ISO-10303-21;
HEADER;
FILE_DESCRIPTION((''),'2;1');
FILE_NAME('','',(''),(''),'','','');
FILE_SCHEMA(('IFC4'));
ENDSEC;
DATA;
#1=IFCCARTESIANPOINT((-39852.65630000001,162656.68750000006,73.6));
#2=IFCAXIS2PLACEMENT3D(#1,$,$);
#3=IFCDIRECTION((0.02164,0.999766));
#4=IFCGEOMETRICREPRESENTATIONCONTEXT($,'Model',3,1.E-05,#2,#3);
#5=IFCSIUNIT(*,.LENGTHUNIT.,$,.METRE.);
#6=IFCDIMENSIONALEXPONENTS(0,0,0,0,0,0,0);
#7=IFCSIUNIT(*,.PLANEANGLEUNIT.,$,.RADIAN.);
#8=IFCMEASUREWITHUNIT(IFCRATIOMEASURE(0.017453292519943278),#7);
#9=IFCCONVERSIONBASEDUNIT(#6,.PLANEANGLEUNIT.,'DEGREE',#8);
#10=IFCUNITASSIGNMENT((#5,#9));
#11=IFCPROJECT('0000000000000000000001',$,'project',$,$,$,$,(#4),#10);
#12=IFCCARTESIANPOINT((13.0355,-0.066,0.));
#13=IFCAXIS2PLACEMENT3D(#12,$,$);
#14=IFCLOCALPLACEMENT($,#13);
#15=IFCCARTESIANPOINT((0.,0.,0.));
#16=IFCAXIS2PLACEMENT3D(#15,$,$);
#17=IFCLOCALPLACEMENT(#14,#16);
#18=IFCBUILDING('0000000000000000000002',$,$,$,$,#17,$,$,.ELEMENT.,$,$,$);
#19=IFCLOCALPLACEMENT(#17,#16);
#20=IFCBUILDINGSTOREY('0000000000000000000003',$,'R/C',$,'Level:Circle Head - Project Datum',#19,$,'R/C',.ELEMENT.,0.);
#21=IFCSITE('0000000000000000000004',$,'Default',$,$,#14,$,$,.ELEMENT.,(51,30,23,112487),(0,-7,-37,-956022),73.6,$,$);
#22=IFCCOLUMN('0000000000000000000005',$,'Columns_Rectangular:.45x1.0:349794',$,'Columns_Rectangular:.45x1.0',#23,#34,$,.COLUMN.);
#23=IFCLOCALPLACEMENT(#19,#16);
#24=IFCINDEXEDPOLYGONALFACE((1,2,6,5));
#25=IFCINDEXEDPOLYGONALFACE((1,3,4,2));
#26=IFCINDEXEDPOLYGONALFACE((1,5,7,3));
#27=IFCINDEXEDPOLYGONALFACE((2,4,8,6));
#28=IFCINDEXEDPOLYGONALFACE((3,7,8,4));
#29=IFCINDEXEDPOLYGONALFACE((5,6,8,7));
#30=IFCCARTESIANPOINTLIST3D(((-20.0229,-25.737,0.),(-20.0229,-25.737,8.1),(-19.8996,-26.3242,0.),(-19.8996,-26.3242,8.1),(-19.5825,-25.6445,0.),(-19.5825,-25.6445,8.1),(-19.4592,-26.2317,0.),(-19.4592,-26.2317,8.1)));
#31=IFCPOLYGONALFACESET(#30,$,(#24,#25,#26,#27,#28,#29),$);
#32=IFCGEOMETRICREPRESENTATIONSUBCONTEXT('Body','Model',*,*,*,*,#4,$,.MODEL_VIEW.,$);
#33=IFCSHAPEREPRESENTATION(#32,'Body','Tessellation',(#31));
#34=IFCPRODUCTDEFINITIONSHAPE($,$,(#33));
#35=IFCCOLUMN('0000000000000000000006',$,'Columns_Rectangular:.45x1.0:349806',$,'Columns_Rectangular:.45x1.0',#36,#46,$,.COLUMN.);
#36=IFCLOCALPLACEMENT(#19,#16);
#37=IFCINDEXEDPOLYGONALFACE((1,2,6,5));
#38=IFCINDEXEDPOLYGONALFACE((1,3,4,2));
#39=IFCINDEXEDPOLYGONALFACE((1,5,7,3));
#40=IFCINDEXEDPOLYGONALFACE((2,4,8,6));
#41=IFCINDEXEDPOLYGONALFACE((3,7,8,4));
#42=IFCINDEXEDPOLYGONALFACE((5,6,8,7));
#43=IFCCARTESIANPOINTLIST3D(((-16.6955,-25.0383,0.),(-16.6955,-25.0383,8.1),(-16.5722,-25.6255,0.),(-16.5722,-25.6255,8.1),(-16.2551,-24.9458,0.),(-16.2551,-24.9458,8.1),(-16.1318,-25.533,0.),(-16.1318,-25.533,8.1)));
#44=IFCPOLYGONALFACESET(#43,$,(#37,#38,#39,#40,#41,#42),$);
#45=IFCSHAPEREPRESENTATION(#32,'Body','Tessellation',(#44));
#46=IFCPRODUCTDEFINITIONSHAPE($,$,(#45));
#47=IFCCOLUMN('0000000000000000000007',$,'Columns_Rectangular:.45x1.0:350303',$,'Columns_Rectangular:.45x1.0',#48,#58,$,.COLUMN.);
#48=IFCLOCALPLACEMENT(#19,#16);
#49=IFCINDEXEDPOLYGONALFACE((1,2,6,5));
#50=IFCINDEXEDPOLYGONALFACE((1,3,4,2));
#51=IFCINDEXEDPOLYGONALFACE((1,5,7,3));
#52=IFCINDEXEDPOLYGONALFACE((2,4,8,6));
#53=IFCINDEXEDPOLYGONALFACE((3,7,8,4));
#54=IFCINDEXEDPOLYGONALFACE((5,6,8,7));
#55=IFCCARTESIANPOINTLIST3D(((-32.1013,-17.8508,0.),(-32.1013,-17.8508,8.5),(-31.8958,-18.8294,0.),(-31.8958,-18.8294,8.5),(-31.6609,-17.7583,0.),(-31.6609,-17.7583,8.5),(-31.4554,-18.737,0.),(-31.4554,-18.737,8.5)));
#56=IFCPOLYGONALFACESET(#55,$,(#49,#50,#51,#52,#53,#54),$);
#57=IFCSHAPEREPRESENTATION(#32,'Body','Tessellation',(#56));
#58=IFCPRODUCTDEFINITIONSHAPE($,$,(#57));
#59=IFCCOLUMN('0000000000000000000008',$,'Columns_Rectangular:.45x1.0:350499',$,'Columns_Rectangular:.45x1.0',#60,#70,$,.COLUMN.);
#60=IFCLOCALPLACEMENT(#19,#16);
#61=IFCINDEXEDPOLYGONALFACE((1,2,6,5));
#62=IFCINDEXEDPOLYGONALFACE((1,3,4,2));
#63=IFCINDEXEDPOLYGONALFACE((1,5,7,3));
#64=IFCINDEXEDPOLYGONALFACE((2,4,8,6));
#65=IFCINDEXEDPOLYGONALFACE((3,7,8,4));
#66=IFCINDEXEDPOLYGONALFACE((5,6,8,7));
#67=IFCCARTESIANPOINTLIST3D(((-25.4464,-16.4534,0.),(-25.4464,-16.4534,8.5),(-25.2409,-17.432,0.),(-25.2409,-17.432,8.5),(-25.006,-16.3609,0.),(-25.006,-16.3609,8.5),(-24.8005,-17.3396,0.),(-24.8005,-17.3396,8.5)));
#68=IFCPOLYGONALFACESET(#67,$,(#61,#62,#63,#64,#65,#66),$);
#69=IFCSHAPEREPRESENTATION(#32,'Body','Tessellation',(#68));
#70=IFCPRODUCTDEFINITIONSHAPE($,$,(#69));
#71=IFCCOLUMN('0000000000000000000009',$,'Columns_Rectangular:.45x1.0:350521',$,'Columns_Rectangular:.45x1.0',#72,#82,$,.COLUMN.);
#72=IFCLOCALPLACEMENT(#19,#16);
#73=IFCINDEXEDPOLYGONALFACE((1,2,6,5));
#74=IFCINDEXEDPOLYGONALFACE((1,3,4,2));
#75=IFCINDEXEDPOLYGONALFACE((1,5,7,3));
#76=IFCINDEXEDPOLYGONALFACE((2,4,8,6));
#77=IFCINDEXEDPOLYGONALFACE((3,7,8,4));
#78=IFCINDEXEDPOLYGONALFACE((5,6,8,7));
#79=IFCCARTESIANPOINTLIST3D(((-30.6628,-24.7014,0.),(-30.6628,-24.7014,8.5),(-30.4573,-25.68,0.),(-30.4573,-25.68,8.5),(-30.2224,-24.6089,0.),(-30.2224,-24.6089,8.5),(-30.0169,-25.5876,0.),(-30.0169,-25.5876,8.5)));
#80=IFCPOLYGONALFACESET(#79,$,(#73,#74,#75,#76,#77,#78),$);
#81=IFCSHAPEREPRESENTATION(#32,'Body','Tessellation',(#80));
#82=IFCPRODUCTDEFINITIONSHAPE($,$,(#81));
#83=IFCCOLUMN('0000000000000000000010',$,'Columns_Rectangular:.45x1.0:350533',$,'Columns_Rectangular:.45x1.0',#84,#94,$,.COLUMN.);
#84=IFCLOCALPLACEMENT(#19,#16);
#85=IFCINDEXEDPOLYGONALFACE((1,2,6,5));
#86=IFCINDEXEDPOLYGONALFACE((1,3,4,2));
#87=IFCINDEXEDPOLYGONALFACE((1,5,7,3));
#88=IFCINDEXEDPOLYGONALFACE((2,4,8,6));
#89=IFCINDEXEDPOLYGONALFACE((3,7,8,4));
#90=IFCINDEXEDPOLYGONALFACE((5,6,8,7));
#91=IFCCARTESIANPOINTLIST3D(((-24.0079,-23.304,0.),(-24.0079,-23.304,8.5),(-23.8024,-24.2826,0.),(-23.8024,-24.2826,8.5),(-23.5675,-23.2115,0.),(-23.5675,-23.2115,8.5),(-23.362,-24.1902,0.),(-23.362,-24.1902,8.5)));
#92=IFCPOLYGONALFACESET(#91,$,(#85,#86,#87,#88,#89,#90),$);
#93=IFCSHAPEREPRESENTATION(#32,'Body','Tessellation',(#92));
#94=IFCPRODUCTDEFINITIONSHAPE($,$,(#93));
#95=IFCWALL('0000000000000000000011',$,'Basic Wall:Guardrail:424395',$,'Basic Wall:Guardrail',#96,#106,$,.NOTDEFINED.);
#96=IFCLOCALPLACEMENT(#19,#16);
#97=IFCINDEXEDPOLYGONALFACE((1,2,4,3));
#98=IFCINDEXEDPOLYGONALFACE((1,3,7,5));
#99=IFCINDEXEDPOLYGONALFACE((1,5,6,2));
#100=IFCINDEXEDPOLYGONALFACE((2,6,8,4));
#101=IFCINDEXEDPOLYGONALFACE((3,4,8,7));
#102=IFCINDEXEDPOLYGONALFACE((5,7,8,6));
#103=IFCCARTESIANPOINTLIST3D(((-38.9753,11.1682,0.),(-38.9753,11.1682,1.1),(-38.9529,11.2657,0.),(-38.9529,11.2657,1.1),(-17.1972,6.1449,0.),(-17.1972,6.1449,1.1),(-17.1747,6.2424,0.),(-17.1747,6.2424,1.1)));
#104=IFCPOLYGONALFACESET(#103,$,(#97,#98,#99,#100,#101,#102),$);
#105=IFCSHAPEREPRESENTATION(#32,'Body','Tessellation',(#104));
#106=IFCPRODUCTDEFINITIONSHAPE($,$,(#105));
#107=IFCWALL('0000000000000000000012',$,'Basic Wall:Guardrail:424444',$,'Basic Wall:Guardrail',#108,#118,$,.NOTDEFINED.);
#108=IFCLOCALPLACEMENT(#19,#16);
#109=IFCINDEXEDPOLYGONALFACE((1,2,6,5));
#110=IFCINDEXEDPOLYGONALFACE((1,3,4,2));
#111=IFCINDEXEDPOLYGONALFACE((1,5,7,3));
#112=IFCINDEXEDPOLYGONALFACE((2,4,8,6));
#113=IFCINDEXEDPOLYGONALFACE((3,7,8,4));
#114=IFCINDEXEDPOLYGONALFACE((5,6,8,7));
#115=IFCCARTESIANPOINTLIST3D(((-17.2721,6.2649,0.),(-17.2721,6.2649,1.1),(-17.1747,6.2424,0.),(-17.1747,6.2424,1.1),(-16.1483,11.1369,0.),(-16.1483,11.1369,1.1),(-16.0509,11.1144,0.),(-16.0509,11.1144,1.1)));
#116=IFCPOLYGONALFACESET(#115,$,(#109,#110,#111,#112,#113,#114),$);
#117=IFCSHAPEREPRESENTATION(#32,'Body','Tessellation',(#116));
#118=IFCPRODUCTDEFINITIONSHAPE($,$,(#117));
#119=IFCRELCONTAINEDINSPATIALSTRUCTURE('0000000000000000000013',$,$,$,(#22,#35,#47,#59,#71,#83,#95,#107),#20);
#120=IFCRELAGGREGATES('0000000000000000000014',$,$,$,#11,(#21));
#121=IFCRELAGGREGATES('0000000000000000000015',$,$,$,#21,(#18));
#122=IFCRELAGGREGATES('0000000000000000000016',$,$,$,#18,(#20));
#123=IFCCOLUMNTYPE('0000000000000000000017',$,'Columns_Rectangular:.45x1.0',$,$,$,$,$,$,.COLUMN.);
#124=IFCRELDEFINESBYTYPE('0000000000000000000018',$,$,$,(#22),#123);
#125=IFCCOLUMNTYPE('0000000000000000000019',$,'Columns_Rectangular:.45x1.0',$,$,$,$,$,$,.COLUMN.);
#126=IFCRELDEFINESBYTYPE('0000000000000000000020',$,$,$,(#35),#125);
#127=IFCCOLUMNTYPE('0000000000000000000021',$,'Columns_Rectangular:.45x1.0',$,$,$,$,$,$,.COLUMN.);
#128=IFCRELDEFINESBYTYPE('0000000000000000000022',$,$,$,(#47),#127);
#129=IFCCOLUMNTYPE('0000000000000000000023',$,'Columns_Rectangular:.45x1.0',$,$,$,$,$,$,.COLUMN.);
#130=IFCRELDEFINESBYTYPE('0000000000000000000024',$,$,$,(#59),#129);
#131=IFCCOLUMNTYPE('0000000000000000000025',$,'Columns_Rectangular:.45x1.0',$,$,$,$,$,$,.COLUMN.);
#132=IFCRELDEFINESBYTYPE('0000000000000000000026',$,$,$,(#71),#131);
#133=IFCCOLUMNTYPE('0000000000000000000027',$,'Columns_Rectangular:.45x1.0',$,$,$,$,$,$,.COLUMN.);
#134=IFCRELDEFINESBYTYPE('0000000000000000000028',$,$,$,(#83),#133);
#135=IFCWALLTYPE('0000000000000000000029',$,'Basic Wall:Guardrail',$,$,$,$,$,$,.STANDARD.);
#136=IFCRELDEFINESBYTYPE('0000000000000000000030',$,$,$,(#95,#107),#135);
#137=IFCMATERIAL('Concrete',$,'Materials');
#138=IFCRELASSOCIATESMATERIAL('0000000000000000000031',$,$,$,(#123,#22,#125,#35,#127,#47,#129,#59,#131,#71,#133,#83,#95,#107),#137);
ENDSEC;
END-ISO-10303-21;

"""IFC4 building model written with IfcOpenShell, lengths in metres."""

from ifc_helpers import new_model, entity, si_unit, converted_unit, direction, frame, origin, place, context, subcontext, project, spatial, indexed_curve, outline, extrude, source, transform, mapped, material, type_object, type_shapes, element, save


model = new_model("IFC4")

# Units and contexts
model_context = context("Model", 3, precision=1e-05, world=frame((-39852.65630000001, 162656.68750000006, 73.6)), true_north=direction((0.02164, 0.999766)))
body_context = subcontext(model_context, "Body", "Model", "MODEL_VIEW")
ifc_project = project(units=[si_unit("LENGTHUNIT", "METRE"), converted_unit("PLANEANGLEUNIT", "DEGREE", entity("IfcRatioMeasure", 0.017453292519943278), si_unit("PLANEANGLEUNIT", "RADIAN"), dimensions=[0, 0, 0, 0, 0, 0, 0])], contexts=[model_context])

# Site, building, storey
site_placement = place(None, frame((13.0355, -0.066, 0.0)))
site = spatial("IfcSite", under=ifc_project, at=site_placement, Name="Default", CompositionType="ELEMENT", RefLatitude=(51, 30, 23, 112487), RefLongitude=(0, -7, -37, -956022), RefElevation=73.6)
building_placement = place(site_placement, origin())
building = spatial("IfcBuilding", under=site, at=building_placement, CompositionType="ELEMENT")
storey_placement = place(building_placement, origin())
storey = spatial("IfcBuildingStorey", under=building, at=storey_placement, Name="R/C", ObjectType="Level:Circle Head - Project Datum", LongName="R/C", CompositionType="ELEMENT", Elevation=0.0)

# Columns
ifc_material = material(Name="Concrete", Category="Materials")
column_type_1 = type_object("IfcColumnType", Name="Columns_Rectangular:.45x1.0", PredefinedType="COLUMN", material=ifc_material)
shared_shape_1 = source(origin(), body_context, "Body", "SweptSolid", [
    extrude(outline(indexed_curve([(-0.3, -0.225), (0.3, -0.225), (0.3, 0.225), (-0.3, 0.225), (-0.3, -0.225)], self_intersect=False)), frame((-19.741, -25.9844, 0.0), z_axis=(0.0, 0.0, 1.0), x_axis=(-0.2055, 0.978657, 0.0)), (0.0, 0.0, 1.0), 8.1),
])
type_shapes(column_type_1, [shared_shape_1])
column_1_placement = place(storey_placement, origin())
element("IfcColumn", 1, at=column_1_placement, inside=storey, type_object=column_type_1, material=ifc_material, Name="Columns_Rectangular:.45x1.0:349794", ObjectType="Columns_Rectangular:.45x1.0", PredefinedType="COLUMN", context=body_context, shape_type="MappedRepresentation", body=[
    mapped(shared_shape_1, transform((0.0, 0.0, 0.0), scale=1.0)),
])
column_type_2 = type_object("IfcColumnType", Name="Columns_Rectangular:.45x1.0", PredefinedType="COLUMN", material=ifc_material)
shared_shape_2 = source(origin(), body_context, "Body", "SweptSolid", [
    extrude(outline(indexed_curve([(-0.3, -0.225), (0.3, -0.225), (0.3, 0.225), (-0.3, 0.225), (-0.3, -0.225)], self_intersect=False)), frame((-16.4136, -25.2857, 0.0), z_axis=(0.0, 0.0, 1.0), x_axis=(-0.2055, 0.978657, 0.0)), (0.0, 0.0, 1.0), 8.1),
])
type_shapes(column_type_2, [shared_shape_2])
column_2_placement = place(storey_placement, origin())
element("IfcColumn", 2, at=column_2_placement, inside=storey, type_object=column_type_2, material=ifc_material, Name="Columns_Rectangular:.45x1.0:349806", ObjectType="Columns_Rectangular:.45x1.0", PredefinedType="COLUMN", context=body_context, shape_type="MappedRepresentation", body=[
    mapped(shared_shape_2, transform((0.0, 0.0, 0.0), scale=1.0)),
])
column_type_3 = type_object("IfcColumnType", Name="Columns_Rectangular:.45x1.0", PredefinedType="COLUMN", material=ifc_material)
shared_shape_3 = source(origin(), body_context, "Body", "SweptSolid", [
    extrude(outline(indexed_curve([(-0.5, -0.225), (0.5, -0.225), (0.5, 0.225), (-0.5, 0.225), (-0.5, -0.225)], self_intersect=False)), frame((-31.7784, -18.2939, 0.0), z_axis=(0.0, 0.0, 1.0), x_axis=(-0.2055, 0.978657, 0.0)), (0.0, 0.0, 1.0), 8.5),
])
type_shapes(column_type_3, [shared_shape_3])
column_3_placement = place(storey_placement, origin())
element("IfcColumn", 3, at=column_3_placement, inside=storey, type_object=column_type_3, material=ifc_material, Name="Columns_Rectangular:.45x1.0:350303", ObjectType="Columns_Rectangular:.45x1.0", PredefinedType="COLUMN", context=body_context, shape_type="MappedRepresentation", body=[
    mapped(shared_shape_3, transform((0.0, 0.0, 0.0), scale=1.0)),
])
column_type_4 = type_object("IfcColumnType", Name="Columns_Rectangular:.45x1.0", PredefinedType="COLUMN", material=ifc_material)
shared_shape_4 = source(origin(), body_context, "Body", "SweptSolid", [
    extrude(outline(indexed_curve([(-0.5, -0.225), (0.5, -0.225), (0.5, 0.225), (-0.5, 0.225), (-0.5, -0.225)], self_intersect=False)), frame((-25.1235, -16.8965, 0.0), z_axis=(0.0, 0.0, 1.0), x_axis=(-0.2055, 0.978657, 0.0)), (0.0, 0.0, 1.0), 8.5),
])
type_shapes(column_type_4, [shared_shape_4])
column_4_placement = place(storey_placement, origin())
element("IfcColumn", 4, at=column_4_placement, inside=storey, type_object=column_type_4, material=ifc_material, Name="Columns_Rectangular:.45x1.0:350499", ObjectType="Columns_Rectangular:.45x1.0", PredefinedType="COLUMN", context=body_context, shape_type="MappedRepresentation", body=[
    mapped(shared_shape_4, transform((0.0, 0.0, 0.0), scale=1.0)),
])
column_type_5 = type_object("IfcColumnType", Name="Columns_Rectangular:.45x1.0", PredefinedType="COLUMN", material=ifc_material)
shared_shape_5 = source(origin(), body_context, "Body", "SweptSolid", [
    extrude(outline(indexed_curve([(-0.5, -0.225), (0.5, -0.225), (0.5, 0.225), (-0.5, 0.225), (-0.5, -0.225)], self_intersect=False)), frame((-30.3399, -25.1445, 0.0), z_axis=(0.0, 0.0, 1.0), x_axis=(-0.2055, 0.978657, 0.0)), (0.0, 0.0, 1.0), 8.5),
])
type_shapes(column_type_5, [shared_shape_5])
column_5_placement = place(storey_placement, origin())
element("IfcColumn", 5, at=column_5_placement, inside=storey, type_object=column_type_5, material=ifc_material, Name="Columns_Rectangular:.45x1.0:350521", ObjectType="Columns_Rectangular:.45x1.0", PredefinedType="COLUMN", context=body_context, shape_type="MappedRepresentation", body=[
    mapped(shared_shape_5, transform((0.0, 0.0, 0.0), scale=1.0)),
])
column_type_6 = type_object("IfcColumnType", Name="Columns_Rectangular:.45x1.0", PredefinedType="COLUMN", material=ifc_material)
shared_shape_6 = source(origin(), body_context, "Body", "SweptSolid", [
    extrude(outline(indexed_curve([(-0.5, -0.225), (0.5, -0.225), (0.5, 0.225), (-0.5, 0.225), (-0.5, -0.225)], self_intersect=False)), frame((-23.685, -23.7471, 0.0), z_axis=(0.0, 0.0, 1.0), x_axis=(-0.2055, 0.978657, 0.0)), (0.0, 0.0, 1.0), 8.5),
])
type_shapes(column_type_6, [shared_shape_6])
column_6_placement = place(storey_placement, origin())
element("IfcColumn", 6, at=column_6_placement, inside=storey, type_object=column_type_6, material=ifc_material, Name="Columns_Rectangular:.45x1.0:350533", ObjectType="Columns_Rectangular:.45x1.0", PredefinedType="COLUMN", context=body_context, shape_type="MappedRepresentation", body=[
    mapped(shared_shape_6, transform((0.0, 0.0, 0.0), scale=1.0)),
])

# Walls
wall_type = type_object("IfcWallType", Name="Basic Wall:Guardrail", PredefinedType="STANDARD")
wall_1_placement = place(storey_placement, frame((-38.9641, 11.217, 0.0), z_axis=(0.0, 0.0, 1.0), x_axis=(0.974415, -0.224757, 0.0)))
element("IfcWall", 7, at=wall_1_placement, inside=storey, type_object=wall_type, material=ifc_material, Name="Basic Wall:Guardrail:424395", ObjectType="Basic Wall:Guardrail", PredefinedType="NOTDEFINED", context=body_context, shape_type="SweptSolid", body=[
    extrude(outline(indexed_curve([(22.35, 0.05), (0.0, 0.05), (0.0, -0.05), (22.35, -0.05), (22.35, 0.05)], self_intersect=False)), origin(), (0.0, 0.0, 1.0), 1.1),
])
wall_2_placement = place(storey_placement, frame((-17.2234, 6.2536, 0.0), z_axis=(0.0, 0.0, 1.0), x_axis=(0.224757, 0.974415, 0.0)))
element("IfcWall", 8, at=wall_2_placement, inside=storey, type_object=wall_type, material=ifc_material, Name="Basic Wall:Guardrail:424444", ObjectType="Basic Wall:Guardrail", PredefinedType="NOTDEFINED", context=body_context, shape_type="SweptSolid", body=[
    extrude(outline(indexed_curve([(5.0, 0.05), (0.0, 0.05), (0.0, -0.05), (5.0, -0.05), (5.0, 0.05)], self_intersect=False)), origin(), (0.0, 0.0, 1.0), 1.1),
])

save(model, "model.ifc")
